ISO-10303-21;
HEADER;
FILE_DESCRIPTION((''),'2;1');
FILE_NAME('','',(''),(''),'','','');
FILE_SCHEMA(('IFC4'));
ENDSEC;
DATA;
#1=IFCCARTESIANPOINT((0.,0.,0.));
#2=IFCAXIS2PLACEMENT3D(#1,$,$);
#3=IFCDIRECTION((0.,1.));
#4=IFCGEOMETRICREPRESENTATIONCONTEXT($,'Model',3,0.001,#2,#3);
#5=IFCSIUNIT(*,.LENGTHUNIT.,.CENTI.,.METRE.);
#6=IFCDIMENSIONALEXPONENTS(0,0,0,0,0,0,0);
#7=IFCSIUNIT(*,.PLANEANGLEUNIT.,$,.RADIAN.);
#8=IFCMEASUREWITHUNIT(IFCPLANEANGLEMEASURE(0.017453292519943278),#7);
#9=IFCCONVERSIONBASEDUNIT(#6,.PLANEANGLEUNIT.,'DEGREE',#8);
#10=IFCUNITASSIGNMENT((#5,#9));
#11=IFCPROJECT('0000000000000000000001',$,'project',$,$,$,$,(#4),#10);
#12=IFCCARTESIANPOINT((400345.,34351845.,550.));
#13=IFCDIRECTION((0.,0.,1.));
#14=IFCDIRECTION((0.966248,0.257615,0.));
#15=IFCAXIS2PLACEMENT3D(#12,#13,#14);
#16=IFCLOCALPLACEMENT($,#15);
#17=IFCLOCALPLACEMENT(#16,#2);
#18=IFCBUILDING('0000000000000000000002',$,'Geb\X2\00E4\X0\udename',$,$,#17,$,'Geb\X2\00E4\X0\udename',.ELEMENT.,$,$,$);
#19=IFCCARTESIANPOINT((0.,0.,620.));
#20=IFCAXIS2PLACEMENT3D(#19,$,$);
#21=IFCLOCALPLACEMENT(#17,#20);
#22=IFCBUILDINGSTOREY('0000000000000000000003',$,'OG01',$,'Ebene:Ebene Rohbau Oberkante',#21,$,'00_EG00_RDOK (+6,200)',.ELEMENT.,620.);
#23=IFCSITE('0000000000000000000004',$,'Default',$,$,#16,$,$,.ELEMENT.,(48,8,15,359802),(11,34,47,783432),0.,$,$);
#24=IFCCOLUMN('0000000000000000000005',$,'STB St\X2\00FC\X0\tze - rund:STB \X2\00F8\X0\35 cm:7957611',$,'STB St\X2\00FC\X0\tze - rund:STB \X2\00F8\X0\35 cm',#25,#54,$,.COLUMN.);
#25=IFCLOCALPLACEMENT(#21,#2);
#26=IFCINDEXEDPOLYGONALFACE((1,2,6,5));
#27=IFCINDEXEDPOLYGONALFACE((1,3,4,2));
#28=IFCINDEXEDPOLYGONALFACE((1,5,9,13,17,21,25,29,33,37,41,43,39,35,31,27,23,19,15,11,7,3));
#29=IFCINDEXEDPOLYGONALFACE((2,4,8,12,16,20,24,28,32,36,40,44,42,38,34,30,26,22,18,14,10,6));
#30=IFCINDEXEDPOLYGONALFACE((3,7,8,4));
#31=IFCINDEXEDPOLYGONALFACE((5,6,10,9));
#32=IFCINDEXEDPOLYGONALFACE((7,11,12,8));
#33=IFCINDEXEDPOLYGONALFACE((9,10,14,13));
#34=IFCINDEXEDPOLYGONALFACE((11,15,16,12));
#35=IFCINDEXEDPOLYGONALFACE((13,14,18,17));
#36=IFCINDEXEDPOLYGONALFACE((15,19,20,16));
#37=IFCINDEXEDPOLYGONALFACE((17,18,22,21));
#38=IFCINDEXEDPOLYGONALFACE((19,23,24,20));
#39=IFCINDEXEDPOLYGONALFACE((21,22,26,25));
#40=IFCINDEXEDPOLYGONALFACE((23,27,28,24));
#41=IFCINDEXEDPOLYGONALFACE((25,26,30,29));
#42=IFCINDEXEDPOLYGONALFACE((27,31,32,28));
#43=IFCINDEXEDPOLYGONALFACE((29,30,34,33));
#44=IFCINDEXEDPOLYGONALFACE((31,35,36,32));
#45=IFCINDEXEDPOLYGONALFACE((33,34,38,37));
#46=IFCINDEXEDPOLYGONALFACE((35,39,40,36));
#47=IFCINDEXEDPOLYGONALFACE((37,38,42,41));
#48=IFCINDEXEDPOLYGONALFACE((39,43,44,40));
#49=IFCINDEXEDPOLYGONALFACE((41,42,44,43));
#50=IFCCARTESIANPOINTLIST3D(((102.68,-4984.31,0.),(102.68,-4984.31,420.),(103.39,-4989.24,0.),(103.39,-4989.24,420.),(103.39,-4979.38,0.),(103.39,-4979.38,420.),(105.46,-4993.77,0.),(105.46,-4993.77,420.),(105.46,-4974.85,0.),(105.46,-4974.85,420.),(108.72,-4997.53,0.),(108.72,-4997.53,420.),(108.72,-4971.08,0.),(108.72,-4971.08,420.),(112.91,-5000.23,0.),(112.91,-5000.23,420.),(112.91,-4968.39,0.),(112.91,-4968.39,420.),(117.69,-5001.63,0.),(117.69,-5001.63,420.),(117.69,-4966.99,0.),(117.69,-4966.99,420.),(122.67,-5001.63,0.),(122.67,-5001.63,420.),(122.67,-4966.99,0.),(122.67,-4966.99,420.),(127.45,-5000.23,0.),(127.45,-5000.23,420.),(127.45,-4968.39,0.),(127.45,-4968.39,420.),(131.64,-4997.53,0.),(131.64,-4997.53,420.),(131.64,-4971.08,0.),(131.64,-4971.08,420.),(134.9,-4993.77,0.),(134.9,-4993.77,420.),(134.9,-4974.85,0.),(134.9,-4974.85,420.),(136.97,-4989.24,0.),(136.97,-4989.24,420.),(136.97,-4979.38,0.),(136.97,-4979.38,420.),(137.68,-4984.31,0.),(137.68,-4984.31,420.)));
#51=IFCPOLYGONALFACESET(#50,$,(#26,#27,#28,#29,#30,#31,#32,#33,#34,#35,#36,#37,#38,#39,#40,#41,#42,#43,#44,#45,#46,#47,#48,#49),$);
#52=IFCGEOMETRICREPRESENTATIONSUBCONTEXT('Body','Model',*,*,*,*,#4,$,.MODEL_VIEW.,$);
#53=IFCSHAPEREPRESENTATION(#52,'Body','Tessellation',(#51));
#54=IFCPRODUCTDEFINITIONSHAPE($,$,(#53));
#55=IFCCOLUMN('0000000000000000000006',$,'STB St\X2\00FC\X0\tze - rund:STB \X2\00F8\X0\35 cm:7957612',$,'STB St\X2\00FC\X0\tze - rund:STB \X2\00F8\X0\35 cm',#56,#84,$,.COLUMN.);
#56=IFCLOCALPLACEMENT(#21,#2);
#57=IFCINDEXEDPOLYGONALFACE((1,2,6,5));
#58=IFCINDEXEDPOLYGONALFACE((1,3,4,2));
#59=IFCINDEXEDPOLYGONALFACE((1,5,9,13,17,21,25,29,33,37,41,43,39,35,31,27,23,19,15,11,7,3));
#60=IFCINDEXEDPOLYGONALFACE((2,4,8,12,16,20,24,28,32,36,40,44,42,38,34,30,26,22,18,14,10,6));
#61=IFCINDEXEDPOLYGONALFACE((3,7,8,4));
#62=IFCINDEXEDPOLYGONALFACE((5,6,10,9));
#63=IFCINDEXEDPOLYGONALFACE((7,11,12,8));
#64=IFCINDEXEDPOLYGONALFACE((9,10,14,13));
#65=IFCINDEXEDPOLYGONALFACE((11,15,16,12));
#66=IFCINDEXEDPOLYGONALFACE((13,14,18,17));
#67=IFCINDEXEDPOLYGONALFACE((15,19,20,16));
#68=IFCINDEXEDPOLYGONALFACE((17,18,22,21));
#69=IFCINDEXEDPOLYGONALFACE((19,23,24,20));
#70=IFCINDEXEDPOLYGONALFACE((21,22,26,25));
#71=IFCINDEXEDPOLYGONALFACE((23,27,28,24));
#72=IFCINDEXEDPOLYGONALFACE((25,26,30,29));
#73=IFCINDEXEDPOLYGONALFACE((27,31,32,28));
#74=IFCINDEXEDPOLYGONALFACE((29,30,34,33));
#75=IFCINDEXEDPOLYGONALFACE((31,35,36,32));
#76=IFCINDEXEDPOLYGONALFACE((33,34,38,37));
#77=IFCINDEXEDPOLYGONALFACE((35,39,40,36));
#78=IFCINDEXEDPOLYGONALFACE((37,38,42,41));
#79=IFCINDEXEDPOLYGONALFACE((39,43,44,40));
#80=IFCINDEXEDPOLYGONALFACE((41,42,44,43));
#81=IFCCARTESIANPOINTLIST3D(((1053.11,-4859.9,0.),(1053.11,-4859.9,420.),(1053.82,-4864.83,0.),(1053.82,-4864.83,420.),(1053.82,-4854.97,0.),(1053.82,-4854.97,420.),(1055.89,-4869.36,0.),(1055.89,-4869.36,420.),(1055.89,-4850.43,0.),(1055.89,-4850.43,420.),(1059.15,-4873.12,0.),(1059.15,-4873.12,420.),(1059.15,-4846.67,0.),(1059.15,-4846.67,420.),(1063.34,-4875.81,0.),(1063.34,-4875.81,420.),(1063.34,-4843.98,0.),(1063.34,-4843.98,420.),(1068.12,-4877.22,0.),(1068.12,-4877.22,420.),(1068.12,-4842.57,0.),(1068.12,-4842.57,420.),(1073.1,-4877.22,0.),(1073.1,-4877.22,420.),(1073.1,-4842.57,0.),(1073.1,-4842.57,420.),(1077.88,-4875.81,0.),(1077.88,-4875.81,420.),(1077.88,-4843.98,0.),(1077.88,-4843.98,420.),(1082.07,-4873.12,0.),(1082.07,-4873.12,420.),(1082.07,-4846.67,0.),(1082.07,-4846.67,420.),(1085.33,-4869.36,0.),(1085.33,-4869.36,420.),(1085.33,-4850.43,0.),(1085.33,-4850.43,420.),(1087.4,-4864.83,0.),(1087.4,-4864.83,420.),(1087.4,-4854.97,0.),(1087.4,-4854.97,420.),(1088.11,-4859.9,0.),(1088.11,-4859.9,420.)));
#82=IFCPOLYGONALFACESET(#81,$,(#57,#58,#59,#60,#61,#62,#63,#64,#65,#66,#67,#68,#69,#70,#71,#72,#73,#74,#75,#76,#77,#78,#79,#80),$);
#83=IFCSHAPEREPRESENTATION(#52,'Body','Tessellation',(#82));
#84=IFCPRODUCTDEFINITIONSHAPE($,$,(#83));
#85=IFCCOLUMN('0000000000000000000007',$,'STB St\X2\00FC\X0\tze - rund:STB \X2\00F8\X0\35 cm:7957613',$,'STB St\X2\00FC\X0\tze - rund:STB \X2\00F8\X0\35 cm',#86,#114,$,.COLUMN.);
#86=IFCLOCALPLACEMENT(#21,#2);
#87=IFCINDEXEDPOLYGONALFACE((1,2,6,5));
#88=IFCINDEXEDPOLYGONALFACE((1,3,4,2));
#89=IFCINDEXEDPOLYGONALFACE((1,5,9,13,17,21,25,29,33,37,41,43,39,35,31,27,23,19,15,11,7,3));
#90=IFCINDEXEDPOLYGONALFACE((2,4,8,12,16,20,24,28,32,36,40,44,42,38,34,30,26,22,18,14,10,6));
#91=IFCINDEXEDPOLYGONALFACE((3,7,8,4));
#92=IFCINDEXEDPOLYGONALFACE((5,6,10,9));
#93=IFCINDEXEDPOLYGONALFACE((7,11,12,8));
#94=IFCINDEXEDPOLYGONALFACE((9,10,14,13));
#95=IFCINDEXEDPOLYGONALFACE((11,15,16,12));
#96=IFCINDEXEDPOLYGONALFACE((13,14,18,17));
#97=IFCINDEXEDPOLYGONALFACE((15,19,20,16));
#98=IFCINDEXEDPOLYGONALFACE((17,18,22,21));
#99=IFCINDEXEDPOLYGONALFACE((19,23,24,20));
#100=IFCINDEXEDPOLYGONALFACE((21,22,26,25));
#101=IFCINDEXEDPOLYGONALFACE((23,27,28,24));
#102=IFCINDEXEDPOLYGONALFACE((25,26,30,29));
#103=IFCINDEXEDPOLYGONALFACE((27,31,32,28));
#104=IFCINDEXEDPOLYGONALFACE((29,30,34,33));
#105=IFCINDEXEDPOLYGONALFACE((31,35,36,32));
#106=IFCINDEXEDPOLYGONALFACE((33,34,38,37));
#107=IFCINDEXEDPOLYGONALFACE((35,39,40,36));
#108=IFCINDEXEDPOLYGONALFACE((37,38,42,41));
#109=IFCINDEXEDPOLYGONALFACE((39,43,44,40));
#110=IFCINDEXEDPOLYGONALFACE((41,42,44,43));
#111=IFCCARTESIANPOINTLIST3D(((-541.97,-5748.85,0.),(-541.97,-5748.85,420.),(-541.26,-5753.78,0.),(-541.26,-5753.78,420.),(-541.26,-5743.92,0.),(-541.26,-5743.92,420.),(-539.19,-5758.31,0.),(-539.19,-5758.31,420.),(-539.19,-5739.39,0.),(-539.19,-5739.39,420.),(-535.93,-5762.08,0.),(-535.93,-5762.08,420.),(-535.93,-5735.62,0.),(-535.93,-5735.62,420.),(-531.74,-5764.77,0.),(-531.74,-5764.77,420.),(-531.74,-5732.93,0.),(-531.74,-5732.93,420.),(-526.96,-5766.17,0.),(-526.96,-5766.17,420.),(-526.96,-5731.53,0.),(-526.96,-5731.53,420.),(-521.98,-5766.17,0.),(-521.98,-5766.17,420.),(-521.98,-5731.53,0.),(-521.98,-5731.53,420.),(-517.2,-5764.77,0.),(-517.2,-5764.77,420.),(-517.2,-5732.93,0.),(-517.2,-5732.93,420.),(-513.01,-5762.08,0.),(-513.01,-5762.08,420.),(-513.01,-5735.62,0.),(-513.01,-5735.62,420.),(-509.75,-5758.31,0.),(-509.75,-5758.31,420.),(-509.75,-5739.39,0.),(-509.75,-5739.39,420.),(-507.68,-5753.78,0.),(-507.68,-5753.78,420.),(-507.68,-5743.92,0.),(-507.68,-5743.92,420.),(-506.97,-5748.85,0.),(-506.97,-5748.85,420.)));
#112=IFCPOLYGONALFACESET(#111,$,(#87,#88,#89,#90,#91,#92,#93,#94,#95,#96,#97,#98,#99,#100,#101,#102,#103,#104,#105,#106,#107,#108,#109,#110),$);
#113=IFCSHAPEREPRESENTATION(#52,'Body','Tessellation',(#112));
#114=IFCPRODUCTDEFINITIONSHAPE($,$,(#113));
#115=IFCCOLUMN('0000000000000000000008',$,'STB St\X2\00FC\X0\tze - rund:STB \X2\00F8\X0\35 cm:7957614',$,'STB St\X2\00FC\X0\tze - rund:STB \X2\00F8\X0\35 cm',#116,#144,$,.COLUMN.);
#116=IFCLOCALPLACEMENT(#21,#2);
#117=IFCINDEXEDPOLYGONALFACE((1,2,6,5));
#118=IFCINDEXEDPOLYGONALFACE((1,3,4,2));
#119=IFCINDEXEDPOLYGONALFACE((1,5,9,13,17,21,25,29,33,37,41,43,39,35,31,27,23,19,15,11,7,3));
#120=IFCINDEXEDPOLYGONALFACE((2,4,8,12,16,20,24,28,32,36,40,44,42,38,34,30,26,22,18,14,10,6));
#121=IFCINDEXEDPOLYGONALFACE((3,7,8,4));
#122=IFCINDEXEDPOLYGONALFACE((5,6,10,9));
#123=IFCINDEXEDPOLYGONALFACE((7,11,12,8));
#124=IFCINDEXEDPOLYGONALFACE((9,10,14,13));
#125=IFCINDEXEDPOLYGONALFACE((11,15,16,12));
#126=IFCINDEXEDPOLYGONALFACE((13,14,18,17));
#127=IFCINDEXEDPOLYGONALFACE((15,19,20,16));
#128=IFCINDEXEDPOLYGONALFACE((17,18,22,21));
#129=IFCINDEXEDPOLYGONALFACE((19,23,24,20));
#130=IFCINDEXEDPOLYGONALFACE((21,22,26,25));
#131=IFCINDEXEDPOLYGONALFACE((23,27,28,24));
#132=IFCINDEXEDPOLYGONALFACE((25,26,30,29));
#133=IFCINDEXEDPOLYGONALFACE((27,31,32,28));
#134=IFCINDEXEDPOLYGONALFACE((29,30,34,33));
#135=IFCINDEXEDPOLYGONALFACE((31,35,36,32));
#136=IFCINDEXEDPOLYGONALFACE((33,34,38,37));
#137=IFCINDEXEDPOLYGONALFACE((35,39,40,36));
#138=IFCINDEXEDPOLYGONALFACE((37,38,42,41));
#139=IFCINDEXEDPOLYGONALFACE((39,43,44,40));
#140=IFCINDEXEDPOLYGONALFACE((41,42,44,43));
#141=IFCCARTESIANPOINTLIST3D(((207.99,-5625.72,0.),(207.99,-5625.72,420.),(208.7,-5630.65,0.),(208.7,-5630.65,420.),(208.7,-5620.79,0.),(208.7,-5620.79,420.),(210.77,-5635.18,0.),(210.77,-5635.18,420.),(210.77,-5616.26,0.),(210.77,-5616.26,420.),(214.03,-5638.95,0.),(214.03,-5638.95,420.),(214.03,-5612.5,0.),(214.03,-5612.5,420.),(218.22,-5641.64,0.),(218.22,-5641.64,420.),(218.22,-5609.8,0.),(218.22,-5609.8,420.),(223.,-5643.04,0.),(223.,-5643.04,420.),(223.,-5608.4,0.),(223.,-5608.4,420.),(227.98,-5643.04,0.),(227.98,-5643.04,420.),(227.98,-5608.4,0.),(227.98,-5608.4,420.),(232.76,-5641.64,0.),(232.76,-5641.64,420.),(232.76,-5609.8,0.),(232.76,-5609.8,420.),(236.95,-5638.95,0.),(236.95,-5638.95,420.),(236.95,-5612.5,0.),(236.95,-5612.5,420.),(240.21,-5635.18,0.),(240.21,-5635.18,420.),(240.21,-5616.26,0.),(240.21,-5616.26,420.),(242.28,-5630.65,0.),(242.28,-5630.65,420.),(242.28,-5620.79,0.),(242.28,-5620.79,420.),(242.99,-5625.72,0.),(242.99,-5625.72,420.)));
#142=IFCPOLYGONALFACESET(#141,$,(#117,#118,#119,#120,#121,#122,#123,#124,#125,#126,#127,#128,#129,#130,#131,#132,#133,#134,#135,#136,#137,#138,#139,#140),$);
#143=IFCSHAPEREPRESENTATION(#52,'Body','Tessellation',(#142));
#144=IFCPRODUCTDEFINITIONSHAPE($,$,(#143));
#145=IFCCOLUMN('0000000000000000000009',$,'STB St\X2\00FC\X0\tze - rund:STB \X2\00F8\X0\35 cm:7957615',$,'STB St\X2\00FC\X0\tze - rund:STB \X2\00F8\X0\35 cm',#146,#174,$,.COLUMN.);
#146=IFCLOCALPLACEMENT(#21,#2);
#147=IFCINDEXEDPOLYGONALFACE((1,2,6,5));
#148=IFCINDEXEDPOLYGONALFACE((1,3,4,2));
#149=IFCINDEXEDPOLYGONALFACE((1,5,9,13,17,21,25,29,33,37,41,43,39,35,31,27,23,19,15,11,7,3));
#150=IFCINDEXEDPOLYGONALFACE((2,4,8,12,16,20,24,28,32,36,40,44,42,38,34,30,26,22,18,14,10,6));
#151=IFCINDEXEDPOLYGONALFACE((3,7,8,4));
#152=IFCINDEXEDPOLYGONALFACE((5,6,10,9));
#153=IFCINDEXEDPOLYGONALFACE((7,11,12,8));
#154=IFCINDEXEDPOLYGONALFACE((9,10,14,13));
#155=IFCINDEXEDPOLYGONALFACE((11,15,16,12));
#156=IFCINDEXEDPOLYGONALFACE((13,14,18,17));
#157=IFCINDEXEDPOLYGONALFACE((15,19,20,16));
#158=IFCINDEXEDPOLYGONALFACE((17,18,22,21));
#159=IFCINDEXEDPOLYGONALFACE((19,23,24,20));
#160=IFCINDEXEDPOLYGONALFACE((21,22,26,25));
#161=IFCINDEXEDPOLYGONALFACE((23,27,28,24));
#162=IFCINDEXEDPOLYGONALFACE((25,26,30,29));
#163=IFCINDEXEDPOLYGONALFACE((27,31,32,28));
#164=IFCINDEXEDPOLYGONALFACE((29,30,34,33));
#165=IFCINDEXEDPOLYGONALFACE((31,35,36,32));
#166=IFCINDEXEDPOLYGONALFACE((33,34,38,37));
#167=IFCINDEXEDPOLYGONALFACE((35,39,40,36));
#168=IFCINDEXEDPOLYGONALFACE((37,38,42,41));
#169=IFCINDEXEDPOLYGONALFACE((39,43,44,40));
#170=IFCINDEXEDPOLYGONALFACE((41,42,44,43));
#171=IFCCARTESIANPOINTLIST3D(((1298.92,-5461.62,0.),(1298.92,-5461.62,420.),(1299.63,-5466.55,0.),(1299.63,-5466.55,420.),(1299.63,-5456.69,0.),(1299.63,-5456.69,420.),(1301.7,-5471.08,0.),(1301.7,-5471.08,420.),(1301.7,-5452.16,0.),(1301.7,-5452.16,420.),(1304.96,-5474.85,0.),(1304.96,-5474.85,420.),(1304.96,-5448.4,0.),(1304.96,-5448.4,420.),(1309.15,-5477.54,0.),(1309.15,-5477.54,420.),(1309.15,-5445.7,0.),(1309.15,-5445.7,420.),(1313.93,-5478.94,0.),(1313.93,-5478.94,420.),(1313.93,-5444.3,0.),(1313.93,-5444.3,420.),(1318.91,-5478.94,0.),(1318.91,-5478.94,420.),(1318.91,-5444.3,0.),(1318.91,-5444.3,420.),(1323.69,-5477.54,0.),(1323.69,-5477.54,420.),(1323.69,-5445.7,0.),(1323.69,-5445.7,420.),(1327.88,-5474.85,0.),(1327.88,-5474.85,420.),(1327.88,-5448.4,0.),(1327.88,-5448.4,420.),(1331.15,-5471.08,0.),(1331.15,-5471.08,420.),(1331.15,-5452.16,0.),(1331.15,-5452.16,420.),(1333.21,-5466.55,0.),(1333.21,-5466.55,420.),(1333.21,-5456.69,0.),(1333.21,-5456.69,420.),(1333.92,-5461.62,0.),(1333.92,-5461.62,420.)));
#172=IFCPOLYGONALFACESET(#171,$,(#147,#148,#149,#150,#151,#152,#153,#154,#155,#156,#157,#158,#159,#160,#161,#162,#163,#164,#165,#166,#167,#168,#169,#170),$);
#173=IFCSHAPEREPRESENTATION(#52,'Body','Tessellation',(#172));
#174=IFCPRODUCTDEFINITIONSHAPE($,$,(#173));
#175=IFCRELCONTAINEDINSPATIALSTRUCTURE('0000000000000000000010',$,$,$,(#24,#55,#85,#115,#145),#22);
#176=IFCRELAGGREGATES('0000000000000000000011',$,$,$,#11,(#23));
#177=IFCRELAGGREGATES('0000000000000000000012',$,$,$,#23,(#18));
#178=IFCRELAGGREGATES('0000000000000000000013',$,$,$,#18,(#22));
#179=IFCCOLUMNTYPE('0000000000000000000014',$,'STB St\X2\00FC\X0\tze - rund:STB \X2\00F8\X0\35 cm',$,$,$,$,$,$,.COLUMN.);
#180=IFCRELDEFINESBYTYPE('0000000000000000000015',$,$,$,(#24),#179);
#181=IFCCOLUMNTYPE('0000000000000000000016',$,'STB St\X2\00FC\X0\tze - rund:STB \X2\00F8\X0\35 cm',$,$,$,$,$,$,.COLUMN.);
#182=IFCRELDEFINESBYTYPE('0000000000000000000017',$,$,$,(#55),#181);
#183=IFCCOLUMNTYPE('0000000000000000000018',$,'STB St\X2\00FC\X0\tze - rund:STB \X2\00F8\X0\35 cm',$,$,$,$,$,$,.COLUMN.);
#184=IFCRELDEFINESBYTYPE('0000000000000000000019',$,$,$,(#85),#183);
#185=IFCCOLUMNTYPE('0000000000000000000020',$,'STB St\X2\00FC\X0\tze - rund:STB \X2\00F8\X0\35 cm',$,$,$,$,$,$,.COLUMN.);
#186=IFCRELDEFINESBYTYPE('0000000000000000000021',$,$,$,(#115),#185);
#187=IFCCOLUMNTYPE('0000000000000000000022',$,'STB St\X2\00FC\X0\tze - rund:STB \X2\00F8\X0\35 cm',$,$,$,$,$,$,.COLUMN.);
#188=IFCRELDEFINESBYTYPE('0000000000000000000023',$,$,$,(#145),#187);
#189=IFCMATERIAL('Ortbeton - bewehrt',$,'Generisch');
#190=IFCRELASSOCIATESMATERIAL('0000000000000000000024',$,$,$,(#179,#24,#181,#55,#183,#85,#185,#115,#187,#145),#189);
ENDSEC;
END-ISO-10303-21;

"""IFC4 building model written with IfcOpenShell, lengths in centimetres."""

from ifc_helpers import new_model, entity, si_unit, converted_unit, direction, frame, origin, place, context, subcontext, project, spatial, arc, indexed_curve, outline, extrude, source, transform, mapped, material, type_object, type_shapes, element, save


model = new_model("IFC4")

# Units and contexts
model_context = context("Model", 3, precision=0.001, world=origin(), true_north=direction((0.0, 1.0)))
body_context = subcontext(model_context, "Body", "Model", "MODEL_VIEW")
ifc_project = project(units=[si_unit("LENGTHUNIT", "METRE", prefix="CENTI"), converted_unit("PLANEANGLEUNIT", "DEGREE", entity("IfcPlaneAngleMeasure", 0.017453292519943278), si_unit("PLANEANGLEUNIT", "RADIAN"), dimensions=[0, 0, 0, 0, 0, 0, 0])], contexts=[model_context])

# Site, building, storey
site_placement = place(None, frame((400345.0, 34351845.0, 550.0), z_axis=(0.0, 0.0, 1.0), x_axis=(0.966248, 0.257615, 0.0)))
site = spatial("IfcSite", under=ifc_project, at=site_placement, Name="Default", CompositionType="ELEMENT", RefLatitude=(48, 8, 15, 359802), RefLongitude=(11, 34, 47, 783432), RefElevation=0.0)
building_placement = place(site_placement, origin())
building = spatial("IfcBuilding", under=site, at=building_placement, Name="Gebäudename", LongName="Gebäudename", CompositionType="ELEMENT")
storey_placement = place(building_placement, frame((0.0, 0.0, 620.0)))
storey = spatial("IfcBuildingStorey", under=building, at=storey_placement, Name="OG01", ObjectType="Ebene:Ebene Rohbau Oberkante", LongName="00_EG00_RDOK (+6,200)", CompositionType="ELEMENT", Elevation=620.0)

# Columns
ifc_material = material(Name="Ortbeton - bewehrt", Category="Generisch")
column_type_1 = type_object("IfcColumnType", Name="STB Stütze - rund:STB ø35 cm", PredefinedType="COLUMN", material=ifc_material)
shared_shape_1 = source(origin(), body_context, "Body", "SweptSolid", [
    extrude(outline(indexed_curve([(-17.5, 0.0), (0.0, -17.5), (17.5, 0.0), (0.0, 17.5)], segments=[arc(1, 2, 3), arc(3, 4, 1)], self_intersect=False)), frame((120.18, -4984.31, 620.0)), (0.0, 0.0, 1.0), 420.0),
])
type_shapes(column_type_1, [shared_shape_1])
column_1_placement = place(storey_placement, frame((0.0, 0.0, -620.0)))
element("IfcColumn", 1, at=column_1_placement, inside=storey, type_object=column_type_1, material=ifc_material, Name="STB Stütze - rund:STB ø35 cm:7957611", ObjectType="STB Stütze - rund:STB ø35 cm", PredefinedType="COLUMN", context=body_context, shape_type="MappedRepresentation", body=[
    mapped(shared_shape_1, transform((0.0, 0.0, 0.0), scale=1.0)),
])
column_type_2 = type_object("IfcColumnType", Name="STB Stütze - rund:STB ø35 cm", PredefinedType="COLUMN", material=ifc_material)
shared_shape_2 = source(origin(), body_context, "Body", "SweptSolid", [
    extrude(outline(indexed_curve([(-17.5, 0.0), (0.0, -17.5), (17.5, 0.0), (0.0, 17.5)], segments=[arc(1, 2, 3), arc(3, 4, 1)], self_intersect=False)), frame((1070.61, -4859.9, 620.0)), (0.0, 0.0, 1.0), 420.0),
])
type_shapes(column_type_2, [shared_shape_2])
column_2_placement = place(storey_placement, frame((0.0, 0.0, -620.0)))
element("IfcColumn", 2, at=column_2_placement, inside=storey, type_object=column_type_2, material=ifc_material, Name="STB Stütze - rund:STB ø35 cm:7957612", ObjectType="STB Stütze - rund:STB ø35 cm", PredefinedType="COLUMN", context=body_context, shape_type="MappedRepresentation", body=[
    mapped(shared_shape_2, transform((0.0, 0.0, 0.0), scale=1.0)),
])
column_type_3 = type_object("IfcColumnType", Name="STB Stütze - rund:STB ø35 cm", PredefinedType="COLUMN", material=ifc_material)
shared_shape_3 = source(origin(), body_context, "Body", "SweptSolid", [
    extrude(outline(indexed_curve([(-17.5, 0.0), (0.0, -17.5), (17.5, 0.0), (0.0, 17.5)], segments=[arc(1, 2, 3), arc(3, 4, 1)], self_intersect=False)), frame((-524.47, -5748.85, 620.0)), (0.0, 0.0, 1.0), 420.0),
])
type_shapes(column_type_3, [shared_shape_3])
column_3_placement = place(storey_placement, frame((0.0, 0.0, -620.0)))
element("IfcColumn", 3, at=column_3_placement, inside=storey, type_object=column_type_3, material=ifc_material, Name="STB Stütze - rund:STB ø35 cm:7957613", ObjectType="STB Stütze - rund:STB ø35 cm", PredefinedType="COLUMN", context=body_context, shape_type="MappedRepresentation", body=[
    mapped(shared_shape_3, transform((0.0, 0.0, 0.0), scale=1.0)),
])
column_type_4 = type_object("IfcColumnType", Name="STB Stütze - rund:STB ø35 cm", PredefinedType="COLUMN", material=ifc_material)
shared_shape_4 = source(origin(), body_context, "Body", "SweptSolid", [
    extrude(outline(indexed_curve([(-17.5, 0.0), (0.0, -17.5), (17.5, 0.0), (0.0, 17.5)], segments=[arc(1, 2, 3), arc(3, 4, 1)], self_intersect=False)), frame((225.49, -5625.72, 620.0)), (0.0, 0.0, 1.0), 420.0),
])
type_shapes(column_type_4, [shared_shape_4])
column_4_placement = place(storey_placement, frame((0.0, 0.0, -620.0)))
element("IfcColumn", 4, at=column_4_placement, inside=storey, type_object=column_type_4, material=ifc_material, Name="STB Stütze - rund:STB ø35 cm:7957614", ObjectType="STB Stütze - rund:STB ø35 cm", PredefinedType="COLUMN", context=body_context, shape_type="MappedRepresentation", body=[
    mapped(shared_shape_4, transform((0.0, 0.0, 0.0), scale=1.0)),
])
column_type_5 = type_object("IfcColumnType", Name="STB Stütze - rund:STB ø35 cm", PredefinedType="COLUMN", material=ifc_material)
shared_shape_5 = source(origin(), body_context, "Body", "SweptSolid", [
    extrude(outline(indexed_curve([(-17.5, 0.0), (0.0, -17.5), (17.5, 0.0), (0.0, 17.5)], segments=[arc(1, 2, 3), arc(3, 4, 1)], self_intersect=False)), frame((1316.42, -5461.62, 620.0)), (0.0, 0.0, 1.0), 420.0),
])
type_shapes(column_type_5, [shared_shape_5])
column_5_placement = place(storey_placement, frame((0.0, 0.0, -620.0)))
element("IfcColumn", 5, at=column_5_placement, inside=storey, type_object=column_type_5, material=ifc_material, Name="STB Stütze - rund:STB ø35 cm:7957615", ObjectType="STB Stütze - rund:STB ø35 cm", PredefinedType="COLUMN", context=body_context, shape_type="MappedRepresentation", body=[
    mapped(shared_shape_5, transform((0.0, 0.0, 0.0), scale=1.0)),
])

save(model, "model.ifc")
